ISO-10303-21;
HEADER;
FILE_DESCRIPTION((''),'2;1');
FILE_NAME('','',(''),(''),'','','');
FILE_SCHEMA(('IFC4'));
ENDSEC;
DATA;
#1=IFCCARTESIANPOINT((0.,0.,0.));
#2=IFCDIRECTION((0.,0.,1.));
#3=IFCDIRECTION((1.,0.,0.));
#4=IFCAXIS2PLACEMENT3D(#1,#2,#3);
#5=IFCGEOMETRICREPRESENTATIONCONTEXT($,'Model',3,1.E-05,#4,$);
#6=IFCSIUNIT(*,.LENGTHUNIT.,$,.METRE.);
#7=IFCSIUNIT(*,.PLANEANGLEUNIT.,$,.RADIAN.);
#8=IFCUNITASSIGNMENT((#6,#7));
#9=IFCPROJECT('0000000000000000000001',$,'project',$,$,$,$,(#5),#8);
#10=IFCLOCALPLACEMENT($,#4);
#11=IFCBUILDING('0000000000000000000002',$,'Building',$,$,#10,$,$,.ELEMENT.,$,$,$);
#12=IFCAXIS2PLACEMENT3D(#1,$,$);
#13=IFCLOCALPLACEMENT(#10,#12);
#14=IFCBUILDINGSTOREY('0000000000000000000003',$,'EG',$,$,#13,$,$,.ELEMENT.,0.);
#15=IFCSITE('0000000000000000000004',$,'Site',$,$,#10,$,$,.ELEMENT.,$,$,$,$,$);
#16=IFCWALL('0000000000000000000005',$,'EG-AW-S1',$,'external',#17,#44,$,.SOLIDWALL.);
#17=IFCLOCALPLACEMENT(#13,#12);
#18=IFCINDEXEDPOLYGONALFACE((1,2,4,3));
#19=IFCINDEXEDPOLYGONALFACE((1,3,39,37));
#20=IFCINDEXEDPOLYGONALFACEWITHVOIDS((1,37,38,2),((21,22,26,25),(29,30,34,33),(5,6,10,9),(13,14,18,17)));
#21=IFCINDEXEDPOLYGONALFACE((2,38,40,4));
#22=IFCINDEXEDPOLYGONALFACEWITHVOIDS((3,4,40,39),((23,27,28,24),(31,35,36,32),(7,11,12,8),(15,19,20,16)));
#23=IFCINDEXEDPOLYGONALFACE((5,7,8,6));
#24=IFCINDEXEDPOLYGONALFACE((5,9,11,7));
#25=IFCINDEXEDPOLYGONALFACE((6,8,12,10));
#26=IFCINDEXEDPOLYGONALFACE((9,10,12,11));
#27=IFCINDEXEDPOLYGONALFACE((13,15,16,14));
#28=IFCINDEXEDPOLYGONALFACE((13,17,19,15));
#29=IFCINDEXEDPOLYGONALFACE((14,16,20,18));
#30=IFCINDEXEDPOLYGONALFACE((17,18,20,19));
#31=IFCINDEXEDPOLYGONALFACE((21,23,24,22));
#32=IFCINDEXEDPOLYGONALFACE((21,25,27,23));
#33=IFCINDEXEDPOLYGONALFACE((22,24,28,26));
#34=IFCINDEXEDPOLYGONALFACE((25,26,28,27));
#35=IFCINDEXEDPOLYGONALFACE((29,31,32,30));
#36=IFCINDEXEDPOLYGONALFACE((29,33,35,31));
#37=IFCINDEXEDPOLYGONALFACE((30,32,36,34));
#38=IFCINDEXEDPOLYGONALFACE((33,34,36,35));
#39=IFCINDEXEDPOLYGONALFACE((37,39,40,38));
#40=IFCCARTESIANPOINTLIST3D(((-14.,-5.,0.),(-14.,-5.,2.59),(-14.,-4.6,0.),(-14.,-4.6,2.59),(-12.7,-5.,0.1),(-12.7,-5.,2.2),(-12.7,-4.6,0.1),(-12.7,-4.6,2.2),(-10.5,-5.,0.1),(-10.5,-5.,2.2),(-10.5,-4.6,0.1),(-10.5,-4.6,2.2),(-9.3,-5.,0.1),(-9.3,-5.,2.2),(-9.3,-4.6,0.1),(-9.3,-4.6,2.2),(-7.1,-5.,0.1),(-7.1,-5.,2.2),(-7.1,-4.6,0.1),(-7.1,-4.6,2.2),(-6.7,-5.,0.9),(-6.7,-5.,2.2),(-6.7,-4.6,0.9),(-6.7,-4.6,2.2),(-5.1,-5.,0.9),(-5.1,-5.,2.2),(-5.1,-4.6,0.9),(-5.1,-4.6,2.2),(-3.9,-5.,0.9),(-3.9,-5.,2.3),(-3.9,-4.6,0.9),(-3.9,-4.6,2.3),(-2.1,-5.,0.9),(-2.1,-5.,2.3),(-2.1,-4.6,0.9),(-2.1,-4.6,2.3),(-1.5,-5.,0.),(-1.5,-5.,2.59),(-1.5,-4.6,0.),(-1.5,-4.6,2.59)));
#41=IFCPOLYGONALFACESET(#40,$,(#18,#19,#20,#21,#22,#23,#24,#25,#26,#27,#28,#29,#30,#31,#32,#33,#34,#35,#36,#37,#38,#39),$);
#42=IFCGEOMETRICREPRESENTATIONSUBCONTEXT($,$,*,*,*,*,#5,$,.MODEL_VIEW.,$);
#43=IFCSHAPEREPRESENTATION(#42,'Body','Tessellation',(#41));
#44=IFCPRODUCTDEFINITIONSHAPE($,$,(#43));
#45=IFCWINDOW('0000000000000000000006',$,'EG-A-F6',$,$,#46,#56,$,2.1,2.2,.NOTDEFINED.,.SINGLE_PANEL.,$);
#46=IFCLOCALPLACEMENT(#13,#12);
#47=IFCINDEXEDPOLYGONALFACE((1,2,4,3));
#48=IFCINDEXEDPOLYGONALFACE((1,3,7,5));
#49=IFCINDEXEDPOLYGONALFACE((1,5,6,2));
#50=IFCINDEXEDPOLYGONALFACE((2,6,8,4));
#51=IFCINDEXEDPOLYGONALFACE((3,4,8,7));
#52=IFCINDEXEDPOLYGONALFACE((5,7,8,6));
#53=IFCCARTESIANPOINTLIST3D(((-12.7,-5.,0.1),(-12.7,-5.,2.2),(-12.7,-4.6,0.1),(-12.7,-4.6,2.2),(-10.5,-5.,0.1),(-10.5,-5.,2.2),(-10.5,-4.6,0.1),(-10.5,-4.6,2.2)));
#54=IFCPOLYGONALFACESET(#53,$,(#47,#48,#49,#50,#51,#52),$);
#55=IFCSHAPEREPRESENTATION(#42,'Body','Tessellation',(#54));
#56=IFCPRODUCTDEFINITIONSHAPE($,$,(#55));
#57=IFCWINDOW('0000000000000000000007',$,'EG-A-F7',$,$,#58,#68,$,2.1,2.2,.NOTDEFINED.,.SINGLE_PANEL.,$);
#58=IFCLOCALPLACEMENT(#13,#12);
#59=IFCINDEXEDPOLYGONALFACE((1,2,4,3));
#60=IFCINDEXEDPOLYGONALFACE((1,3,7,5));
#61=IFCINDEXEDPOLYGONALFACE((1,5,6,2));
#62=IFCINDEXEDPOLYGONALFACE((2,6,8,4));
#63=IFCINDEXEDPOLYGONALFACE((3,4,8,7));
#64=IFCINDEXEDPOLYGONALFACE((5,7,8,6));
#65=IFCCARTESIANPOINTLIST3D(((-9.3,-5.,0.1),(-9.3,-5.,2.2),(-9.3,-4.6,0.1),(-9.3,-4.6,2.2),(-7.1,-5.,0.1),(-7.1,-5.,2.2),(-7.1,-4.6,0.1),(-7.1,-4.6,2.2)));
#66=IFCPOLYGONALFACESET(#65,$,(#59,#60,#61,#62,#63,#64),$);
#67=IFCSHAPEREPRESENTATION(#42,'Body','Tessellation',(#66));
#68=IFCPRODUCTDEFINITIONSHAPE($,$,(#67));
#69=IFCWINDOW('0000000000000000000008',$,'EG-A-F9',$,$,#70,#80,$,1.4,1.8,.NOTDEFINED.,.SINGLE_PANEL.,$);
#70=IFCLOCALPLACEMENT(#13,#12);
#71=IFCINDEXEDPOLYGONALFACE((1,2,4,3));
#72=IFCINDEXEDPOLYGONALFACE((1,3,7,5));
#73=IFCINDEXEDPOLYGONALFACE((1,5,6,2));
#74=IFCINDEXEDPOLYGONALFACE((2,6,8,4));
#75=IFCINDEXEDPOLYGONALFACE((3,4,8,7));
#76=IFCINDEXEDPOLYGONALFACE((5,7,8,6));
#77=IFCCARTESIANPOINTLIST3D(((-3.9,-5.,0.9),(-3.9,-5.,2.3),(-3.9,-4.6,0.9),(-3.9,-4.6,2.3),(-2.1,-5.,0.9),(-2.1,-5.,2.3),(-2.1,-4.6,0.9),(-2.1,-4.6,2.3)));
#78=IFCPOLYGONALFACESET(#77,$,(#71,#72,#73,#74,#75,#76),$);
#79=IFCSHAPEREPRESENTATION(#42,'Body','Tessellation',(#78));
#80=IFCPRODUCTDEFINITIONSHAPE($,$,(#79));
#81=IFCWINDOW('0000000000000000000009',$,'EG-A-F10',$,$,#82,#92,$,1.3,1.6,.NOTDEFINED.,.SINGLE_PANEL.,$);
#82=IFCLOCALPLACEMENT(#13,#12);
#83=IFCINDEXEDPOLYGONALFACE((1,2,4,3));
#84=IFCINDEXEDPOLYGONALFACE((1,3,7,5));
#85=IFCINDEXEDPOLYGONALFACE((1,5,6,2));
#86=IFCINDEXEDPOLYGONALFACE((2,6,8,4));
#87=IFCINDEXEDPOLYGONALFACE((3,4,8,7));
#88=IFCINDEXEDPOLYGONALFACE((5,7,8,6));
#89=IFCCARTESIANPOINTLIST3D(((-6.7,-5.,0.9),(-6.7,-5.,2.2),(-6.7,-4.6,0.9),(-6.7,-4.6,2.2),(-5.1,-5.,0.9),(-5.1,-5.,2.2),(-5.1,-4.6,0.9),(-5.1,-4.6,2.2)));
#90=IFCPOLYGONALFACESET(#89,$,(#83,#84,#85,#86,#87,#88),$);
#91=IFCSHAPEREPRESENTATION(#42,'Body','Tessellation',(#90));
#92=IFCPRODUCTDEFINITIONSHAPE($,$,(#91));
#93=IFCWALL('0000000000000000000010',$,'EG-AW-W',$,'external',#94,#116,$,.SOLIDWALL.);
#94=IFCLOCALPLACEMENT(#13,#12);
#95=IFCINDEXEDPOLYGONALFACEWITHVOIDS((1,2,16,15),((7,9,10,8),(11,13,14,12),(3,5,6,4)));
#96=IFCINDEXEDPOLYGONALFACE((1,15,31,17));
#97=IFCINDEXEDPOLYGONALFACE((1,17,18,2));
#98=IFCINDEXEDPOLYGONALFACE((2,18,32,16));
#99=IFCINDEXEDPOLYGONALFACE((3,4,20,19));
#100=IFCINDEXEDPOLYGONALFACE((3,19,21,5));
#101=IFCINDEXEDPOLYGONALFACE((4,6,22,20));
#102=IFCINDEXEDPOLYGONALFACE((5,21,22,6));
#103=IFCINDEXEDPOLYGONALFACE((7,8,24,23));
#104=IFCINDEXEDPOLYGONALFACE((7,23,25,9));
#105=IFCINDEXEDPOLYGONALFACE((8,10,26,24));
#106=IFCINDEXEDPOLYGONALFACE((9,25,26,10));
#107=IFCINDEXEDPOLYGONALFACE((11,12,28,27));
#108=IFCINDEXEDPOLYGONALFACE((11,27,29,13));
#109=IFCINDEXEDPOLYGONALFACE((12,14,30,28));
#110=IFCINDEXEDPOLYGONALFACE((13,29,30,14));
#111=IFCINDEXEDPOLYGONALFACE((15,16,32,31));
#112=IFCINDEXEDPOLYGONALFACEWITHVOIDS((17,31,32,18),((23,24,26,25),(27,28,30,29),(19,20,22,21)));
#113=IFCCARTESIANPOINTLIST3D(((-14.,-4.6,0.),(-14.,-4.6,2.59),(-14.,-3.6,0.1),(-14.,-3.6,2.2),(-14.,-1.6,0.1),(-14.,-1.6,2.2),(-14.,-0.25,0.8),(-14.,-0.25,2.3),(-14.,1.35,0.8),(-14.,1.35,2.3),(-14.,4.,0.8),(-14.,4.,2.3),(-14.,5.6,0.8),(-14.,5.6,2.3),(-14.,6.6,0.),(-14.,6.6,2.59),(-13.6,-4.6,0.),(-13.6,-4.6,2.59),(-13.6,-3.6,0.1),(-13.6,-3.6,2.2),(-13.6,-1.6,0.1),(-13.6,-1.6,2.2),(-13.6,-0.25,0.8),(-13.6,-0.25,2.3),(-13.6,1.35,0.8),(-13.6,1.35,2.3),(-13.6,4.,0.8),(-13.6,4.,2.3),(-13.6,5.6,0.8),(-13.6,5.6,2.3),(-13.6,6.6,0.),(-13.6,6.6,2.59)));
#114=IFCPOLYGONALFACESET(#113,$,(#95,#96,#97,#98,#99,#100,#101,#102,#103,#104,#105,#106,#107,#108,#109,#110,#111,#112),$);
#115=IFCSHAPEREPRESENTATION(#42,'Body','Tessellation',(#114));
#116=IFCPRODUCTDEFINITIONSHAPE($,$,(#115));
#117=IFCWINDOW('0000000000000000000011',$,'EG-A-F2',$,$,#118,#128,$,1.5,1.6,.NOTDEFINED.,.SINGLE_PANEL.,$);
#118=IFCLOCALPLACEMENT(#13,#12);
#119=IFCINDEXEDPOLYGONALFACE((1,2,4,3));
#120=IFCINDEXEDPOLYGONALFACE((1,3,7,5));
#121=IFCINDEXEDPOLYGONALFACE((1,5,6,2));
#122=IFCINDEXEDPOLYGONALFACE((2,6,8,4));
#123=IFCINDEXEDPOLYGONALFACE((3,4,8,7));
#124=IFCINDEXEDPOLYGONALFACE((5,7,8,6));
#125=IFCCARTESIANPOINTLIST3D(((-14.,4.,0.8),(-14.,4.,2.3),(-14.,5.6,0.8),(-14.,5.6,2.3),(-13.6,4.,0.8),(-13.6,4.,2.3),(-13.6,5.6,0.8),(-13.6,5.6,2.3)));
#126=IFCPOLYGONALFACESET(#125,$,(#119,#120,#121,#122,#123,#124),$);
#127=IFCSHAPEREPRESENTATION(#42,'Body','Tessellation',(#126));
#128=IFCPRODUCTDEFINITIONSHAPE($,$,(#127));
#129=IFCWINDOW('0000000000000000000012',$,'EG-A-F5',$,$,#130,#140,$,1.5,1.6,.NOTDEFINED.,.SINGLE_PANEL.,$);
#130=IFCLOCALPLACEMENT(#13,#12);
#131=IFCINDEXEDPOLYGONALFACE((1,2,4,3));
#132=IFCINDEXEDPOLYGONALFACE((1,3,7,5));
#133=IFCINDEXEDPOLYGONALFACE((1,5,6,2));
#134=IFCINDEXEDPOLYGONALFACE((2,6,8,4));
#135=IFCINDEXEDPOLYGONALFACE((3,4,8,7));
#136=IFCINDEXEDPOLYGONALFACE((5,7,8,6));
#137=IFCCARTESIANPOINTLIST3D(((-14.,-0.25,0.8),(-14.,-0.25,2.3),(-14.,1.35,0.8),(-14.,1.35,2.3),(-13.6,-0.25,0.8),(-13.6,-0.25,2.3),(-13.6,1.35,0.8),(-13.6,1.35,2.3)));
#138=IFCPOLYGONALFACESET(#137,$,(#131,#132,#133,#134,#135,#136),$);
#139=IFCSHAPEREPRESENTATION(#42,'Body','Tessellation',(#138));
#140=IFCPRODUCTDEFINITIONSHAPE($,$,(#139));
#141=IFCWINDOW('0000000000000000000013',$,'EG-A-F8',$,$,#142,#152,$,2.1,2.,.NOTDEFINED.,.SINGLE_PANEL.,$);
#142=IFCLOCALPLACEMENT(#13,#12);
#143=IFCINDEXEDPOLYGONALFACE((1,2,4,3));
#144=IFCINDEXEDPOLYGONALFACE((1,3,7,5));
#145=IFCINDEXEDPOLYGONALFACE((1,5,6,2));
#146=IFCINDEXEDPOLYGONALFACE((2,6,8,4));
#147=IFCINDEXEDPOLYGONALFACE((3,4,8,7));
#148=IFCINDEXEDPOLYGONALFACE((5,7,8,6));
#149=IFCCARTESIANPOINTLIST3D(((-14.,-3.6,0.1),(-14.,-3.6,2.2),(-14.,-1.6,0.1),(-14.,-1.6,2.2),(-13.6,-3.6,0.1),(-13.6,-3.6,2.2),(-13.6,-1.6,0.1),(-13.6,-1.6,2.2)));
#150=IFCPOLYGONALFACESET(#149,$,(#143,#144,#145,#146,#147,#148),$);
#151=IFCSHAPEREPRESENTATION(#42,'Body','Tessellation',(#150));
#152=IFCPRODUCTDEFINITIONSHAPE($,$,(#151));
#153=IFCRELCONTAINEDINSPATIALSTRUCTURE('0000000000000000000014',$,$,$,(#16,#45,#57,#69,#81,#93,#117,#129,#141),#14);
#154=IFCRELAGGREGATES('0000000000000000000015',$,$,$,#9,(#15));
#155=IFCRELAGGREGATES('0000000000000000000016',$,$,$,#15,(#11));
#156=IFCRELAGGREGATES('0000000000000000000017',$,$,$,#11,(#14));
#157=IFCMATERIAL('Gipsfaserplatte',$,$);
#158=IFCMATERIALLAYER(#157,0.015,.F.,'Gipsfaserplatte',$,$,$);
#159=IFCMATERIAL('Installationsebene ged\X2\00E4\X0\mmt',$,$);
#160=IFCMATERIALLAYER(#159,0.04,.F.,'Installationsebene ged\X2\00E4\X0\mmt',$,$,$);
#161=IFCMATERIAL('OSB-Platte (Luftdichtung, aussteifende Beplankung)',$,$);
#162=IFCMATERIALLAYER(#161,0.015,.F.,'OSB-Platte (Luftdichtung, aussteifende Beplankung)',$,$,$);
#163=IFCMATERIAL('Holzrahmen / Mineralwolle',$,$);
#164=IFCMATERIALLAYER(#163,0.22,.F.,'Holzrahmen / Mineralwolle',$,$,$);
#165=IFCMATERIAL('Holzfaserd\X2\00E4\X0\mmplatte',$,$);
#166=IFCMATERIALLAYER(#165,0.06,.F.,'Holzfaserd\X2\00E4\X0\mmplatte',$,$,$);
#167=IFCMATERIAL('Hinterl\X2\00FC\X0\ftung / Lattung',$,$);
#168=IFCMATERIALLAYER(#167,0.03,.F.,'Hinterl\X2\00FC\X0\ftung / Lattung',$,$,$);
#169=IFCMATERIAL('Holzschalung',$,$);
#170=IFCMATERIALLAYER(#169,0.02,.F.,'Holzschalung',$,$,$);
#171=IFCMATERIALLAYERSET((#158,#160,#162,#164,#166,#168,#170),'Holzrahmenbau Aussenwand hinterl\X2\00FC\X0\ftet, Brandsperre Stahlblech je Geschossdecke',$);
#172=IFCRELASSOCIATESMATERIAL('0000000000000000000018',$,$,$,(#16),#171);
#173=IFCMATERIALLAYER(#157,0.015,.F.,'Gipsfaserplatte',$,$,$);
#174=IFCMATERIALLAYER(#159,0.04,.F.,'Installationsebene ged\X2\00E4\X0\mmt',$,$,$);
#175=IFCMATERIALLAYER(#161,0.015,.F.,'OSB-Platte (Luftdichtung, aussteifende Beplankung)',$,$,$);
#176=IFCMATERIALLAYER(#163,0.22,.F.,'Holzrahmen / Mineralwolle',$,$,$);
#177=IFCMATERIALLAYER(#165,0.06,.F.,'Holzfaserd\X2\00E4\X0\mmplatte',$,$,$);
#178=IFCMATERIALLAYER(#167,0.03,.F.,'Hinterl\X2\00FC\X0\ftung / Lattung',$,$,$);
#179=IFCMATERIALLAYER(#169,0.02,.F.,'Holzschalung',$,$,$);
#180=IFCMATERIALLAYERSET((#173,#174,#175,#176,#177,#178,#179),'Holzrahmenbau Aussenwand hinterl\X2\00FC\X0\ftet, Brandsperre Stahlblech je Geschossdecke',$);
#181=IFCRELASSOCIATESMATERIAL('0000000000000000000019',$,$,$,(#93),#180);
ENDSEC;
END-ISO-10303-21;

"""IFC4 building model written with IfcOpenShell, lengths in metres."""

from ifc_helpers import new_model, si_unit, frame, frame_2d, origin, origin_with_axes, place, context, subcontext, project, spatial, rectangle, extrude, material, layer, layer_set, element, fill, save


model = new_model("IFC4")

# Units and contexts
model_context = context("Model", 3, precision=1e-05, world=origin_with_axes())
sub_context = subcontext(model_context, None, None, "MODEL_VIEW")
ifc_project = project(units=[si_unit("LENGTHUNIT", "METRE"), si_unit("PLANEANGLEUNIT", "RADIAN")], contexts=[model_context])

# Site, building, storey
placement = place(None, origin_with_axes())
site = spatial("IfcSite", under=ifc_project, at=placement, Name="Site", CompositionType="ELEMENT")
building = spatial("IfcBuilding", under=site, at=placement, Name="Building", CompositionType="ELEMENT")
storey_placement = place(placement, origin())
storey = spatial("IfcBuildingStorey", under=building, at=storey_placement, Name="EG", CompositionType="ELEMENT", Elevation=0.0)

# Walls, openings, windows
ifc_material_1 = material(Name="Gipsfaserplatte")
ifc_layer_1 = layer(ifc_material_1, 0.015, ventilated=False, Name="Gipsfaserplatte")
ifc_material_2 = material(Name="Installationsebene gedämmt")
ifc_layer_2 = layer(ifc_material_2, 0.04, ventilated=False, Name="Installationsebene gedämmt")
ifc_material_3 = material(Name="OSB-Platte (Luftdichtung, aussteifende Beplankung)")
ifc_layer_3 = layer(ifc_material_3, 0.015, ventilated=False, Name="OSB-Platte (Luftdichtung, aussteifende Beplankung)")
ifc_material_4 = material(Name="Holzrahmen / Mineralwolle")
ifc_layer_4 = layer(ifc_material_4, 0.22, ventilated=False, Name="Holzrahmen / Mineralwolle")
ifc_material_5 = material(Name="Holzfaserdämmplatte")
ifc_layer_5 = layer(ifc_material_5, 0.06, ventilated=False, Name="Holzfaserdämmplatte")
ifc_material_6 = material(Name="Hinterlüftung / Lattung")
ifc_layer_6 = layer(ifc_material_6, 0.03, ventilated=False, Name="Hinterlüftung / Lattung")
ifc_material_7 = material(Name="Holzschalung")
ifc_layer_7 = layer(ifc_material_7, 0.02, ventilated=False, Name="Holzschalung")
ifc_layer_set_1 = layer_set([ifc_layer_1, ifc_layer_2, ifc_layer_3, ifc_layer_4, ifc_layer_5, ifc_layer_6, ifc_layer_7], Name="Holzrahmenbau Aussenwand hinterlüftet, Brandsperre Stahlblech je Geschossdecke")
wall_1_placement = place(storey_placement, frame((-14.0, -4.8, 0.0), z_axis=(0.0, 0.0, 1.0), x_axis=(1.0, 0.0, 0.0)))
wall_1 = element("IfcWall", 1, at=wall_1_placement, inside=storey, material=ifc_layer_set_1, Name="EG-AW-S1", ObjectType="external", PredefinedType="SOLIDWALL", context=sub_context, shape_type="SweptSolid", body=[
    extrude(rectangle(XDim=12.5, YDim=0.4, at=frame_2d((6.25, 0.0))), origin(), (0.0, 0.0, 1.0), 2.59),
])
opening_1_placement = place(wall_1_placement, frame((2.4, 0.25, 0.1), z_axis=(0.0, -1.0, 0.0), x_axis=(1.0, 0.0, 0.0)))
opening_1 = element("IfcOpeningElement", 2, at=opening_1_placement, cuts=wall_1, PredefinedType="OPENING", context=sub_context, shape_type="SweptSolid", body=[
    extrude(rectangle(XDim=2.2, YDim=2.1, at=frame_2d((0.0, 1.05))), origin(), (0.0, 0.0, 1.0), 0.5),
])
opening_2_placement = place(wall_1_placement, frame((5.8, 0.25, 0.1), z_axis=(0.0, -1.0, 0.0), x_axis=(1.0, 0.0, 0.0)))
opening_2 = element("IfcOpeningElement", 3, at=opening_2_placement, cuts=wall_1, PredefinedType="OPENING", context=sub_context, shape_type="SweptSolid", body=[
    extrude(rectangle(XDim=2.2, YDim=2.1, at=frame_2d((0.0, 1.05))), origin(), (0.0, 0.0, 1.0), 0.5),
])
opening_3_placement = place(wall_1_placement, frame((11.0, 0.25, 0.9), z_axis=(0.0, -1.0, 0.0), x_axis=(1.0, 0.0, 0.0)))
opening_3 = element("IfcOpeningElement", 4, at=opening_3_placement, cuts=wall_1, PredefinedType="OPENING", context=sub_context, shape_type="SweptSolid", body=[
    extrude(rectangle(XDim=1.8, YDim=1.4, at=frame_2d((0.0, 0.7))), origin(), (0.0, 0.0, 1.0), 0.5),
])
opening_4_placement = place(wall_1_placement, frame((8.1, 0.25, 0.9), z_axis=(0.0, -1.0, 0.0), x_axis=(1.0, 0.0, 0.0)))
opening_4 = element("IfcOpeningElement", 5, at=opening_4_placement, cuts=wall_1, PredefinedType="OPENING", context=sub_context, shape_type="SweptSolid", body=[
    extrude(rectangle(XDim=1.6, YDim=1.3, at=frame_2d((0.0, 0.65))), origin(), (0.0, 0.0, 1.0), 0.5),
])
window_1_placement = place(wall_1_placement, frame((2.4, 0.2, 0.1), z_axis=(0.0, -1.0, 0.0), x_axis=(1.0, 0.0, 0.0)))
window_1 = element("IfcWindow", 6, at=window_1_placement, inside=storey, Name="EG-A-F6", OverallHeight=2.1, OverallWidth=2.2, PartitioningType="SINGLE_PANEL", PredefinedType="NOTDEFINED", context=sub_context, shape_type="SweptSolid", body=[
    extrude(rectangle(XDim=2.2, YDim=2.1, at=frame_2d((0.0, 1.05))), origin(), (0.0, 0.0, 1.0), 0.4),
])
fill(opening_1, window_1)
window_2_placement = place(wall_1_placement, frame((5.8, 0.2, 0.1), z_axis=(0.0, -1.0, 0.0), x_axis=(1.0, 0.0, 0.0)))
window_2 = element("IfcWindow", 7, at=window_2_placement, inside=storey, Name="EG-A-F7", OverallHeight=2.1, OverallWidth=2.2, PartitioningType="SINGLE_PANEL", PredefinedType="NOTDEFINED", context=sub_context, shape_type="SweptSolid", body=[
    extrude(rectangle(XDim=2.2, YDim=2.1, at=frame_2d((0.0, 1.05))), origin(), (0.0, 0.0, 1.0), 0.4),
])
fill(opening_2, window_2)
window_3_placement = place(wall_1_placement, frame((11.0, 0.2, 0.9), z_axis=(0.0, -1.0, 0.0), x_axis=(1.0, 0.0, 0.0)))
window_3 = element("IfcWindow", 8, at=window_3_placement, inside=storey, Name="EG-A-F9", OverallHeight=1.4, OverallWidth=1.8, PartitioningType="SINGLE_PANEL", PredefinedType="NOTDEFINED", context=sub_context, shape_type="SweptSolid", body=[
    extrude(rectangle(XDim=1.8, YDim=1.4, at=frame_2d((0.0, 0.7))), origin(), (0.0, 0.0, 1.0), 0.4),
])
fill(opening_3, window_3)
window_4_placement = place(wall_1_placement, frame((8.1, 0.2, 0.9), z_axis=(0.0, -1.0, 0.0), x_axis=(1.0, 0.0, 0.0)))
window_4 = element("IfcWindow", 9, at=window_4_placement, inside=storey, Name="EG-A-F10", OverallHeight=1.3, OverallWidth=1.6, PartitioningType="SINGLE_PANEL", PredefinedType="NOTDEFINED", context=sub_context, shape_type="SweptSolid", body=[
    extrude(rectangle(XDim=1.6, YDim=1.3, at=frame_2d((0.0, 0.65))), origin(), (0.0, 0.0, 1.0), 0.4),
])
fill(opening_4, window_4)
ifc_layer_8 = layer(ifc_material_1, 0.015, ventilated=False, Name="Gipsfaserplatte")
ifc_layer_9 = layer(ifc_material_2, 0.04, ventilated=False, Name="Installationsebene gedämmt")
ifc_layer_10 = layer(ifc_material_3, 0.015, ventilated=False, Name="OSB-Platte (Luftdichtung, aussteifende Beplankung)")
ifc_layer_11 = layer(ifc_material_4, 0.22, ventilated=False, Name="Holzrahmen / Mineralwolle")
ifc_layer_12 = layer(ifc_material_5, 0.06, ventilated=False, Name="Holzfaserdämmplatte")
ifc_layer_13 = layer(ifc_material_6, 0.03, ventilated=False, Name="Hinterlüftung / Lattung")
ifc_layer_14 = layer(ifc_material_7, 0.02, ventilated=False, Name="Holzschalung")
ifc_layer_set_2 = layer_set([ifc_layer_8, ifc_layer_9, ifc_layer_10, ifc_layer_11, ifc_layer_12, ifc_layer_13, ifc_layer_14], Name="Holzrahmenbau Aussenwand hinterlüftet, Brandsperre Stahlblech je Geschossdecke")
wall_2_placement = place(storey_placement, frame((-13.8, -4.6, 0.0), z_axis=(0.0, 0.0, 1.0), x_axis=(0.0, 1.0, 0.0)))
wall_2 = element("IfcWall", 10, at=wall_2_placement, inside=storey, material=ifc_layer_set_2, Name="EG-AW-W", ObjectType="external", PredefinedType="SOLIDWALL", context=sub_context, shape_type="SweptSolid", body=[
    extrude(rectangle(XDim=11.2, YDim=0.4, at=frame_2d((5.6, 0.0))), origin(), (0.0, 0.0, 1.0), 2.59),
])
opening_5_placement = place(wall_2_placement, frame((9.4, 0.25, 0.8), z_axis=(0.0, -1.0, 0.0), x_axis=(1.0, 0.0, 0.0)))
opening_5 = element("IfcOpeningElement", 11, at=opening_5_placement, cuts=wall_2, PredefinedType="OPENING", context=sub_context, shape_type="SweptSolid", body=[
    extrude(rectangle(XDim=1.6, YDim=1.5, at=frame_2d((0.0, 0.75))), origin(), (0.0, 0.0, 1.0), 0.5),
])
opening_6_placement = place(wall_2_placement, frame((5.15, 0.25, 0.8), z_axis=(0.0, -1.0, 0.0), x_axis=(1.0, 0.0, 0.0)))
opening_6 = element("IfcOpeningElement", 12, at=opening_6_placement, cuts=wall_2, PredefinedType="OPENING", context=sub_context, shape_type="SweptSolid", body=[
    extrude(rectangle(XDim=1.6, YDim=1.5, at=frame_2d((0.0, 0.75))), origin(), (0.0, 0.0, 1.0), 0.5),
])
opening_7_placement = place(wall_2_placement, frame((2.0, 0.25, 0.1), z_axis=(0.0, -1.0, 0.0), x_axis=(1.0, 0.0, 0.0)))
opening_7 = element("IfcOpeningElement", 13, at=opening_7_placement, cuts=wall_2, PredefinedType="OPENING", context=sub_context, shape_type="SweptSolid", body=[
    extrude(rectangle(XDim=2.0, YDim=2.1, at=frame_2d((0.0, 1.05))), origin(), (0.0, 0.0, 1.0), 0.5),
])
window_5_placement = place(wall_2_placement, frame((9.4, 0.2, 0.8), z_axis=(0.0, -1.0, 0.0), x_axis=(1.0, 0.0, 0.0)))
window_5 = element("IfcWindow", 14, at=window_5_placement, inside=storey, Name="EG-A-F2", OverallHeight=1.5, OverallWidth=1.6, PartitioningType="SINGLE_PANEL", PredefinedType="NOTDEFINED", context=sub_context, shape_type="SweptSolid", body=[
    extrude(rectangle(XDim=1.6, YDim=1.5, at=frame_2d((0.0, 0.75))), origin(), (0.0, 0.0, 1.0), 0.4),
])
fill(opening_5, window_5)
window_6_placement = place(wall_2_placement, frame((5.15, 0.2, 0.8), z_axis=(0.0, -1.0, 0.0), x_axis=(1.0, 0.0, 0.0)))
window_6 = element("IfcWindow", 15, at=window_6_placement, inside=storey, Name="EG-A-F5", OverallHeight=1.5, OverallWidth=1.6, PartitioningType="SINGLE_PANEL", PredefinedType="NOTDEFINED", context=sub_context, shape_type="SweptSolid", body=[
    extrude(rectangle(XDim=1.6, YDim=1.5, at=frame_2d((0.0, 0.75))), origin(), (0.0, 0.0, 1.0), 0.4),
])
fill(opening_6, window_6)
window_7_placement = place(wall_2_placement, frame((2.0, 0.2, 0.1), z_axis=(0.0, -1.0, 0.0), x_axis=(1.0, 0.0, 0.0)))
window_7 = element("IfcWindow", 16, at=window_7_placement, inside=storey, Name="EG-A-F8", OverallHeight=2.1, OverallWidth=2.0, PartitioningType="SINGLE_PANEL", PredefinedType="NOTDEFINED", context=sub_context, shape_type="SweptSolid", body=[
    extrude(rectangle(XDim=2.0, YDim=2.1, at=frame_2d((0.0, 1.05))), origin(), (0.0, 0.0, 1.0), 0.4),
])
fill(opening_7, window_7)

save(model, "model.ifc")
